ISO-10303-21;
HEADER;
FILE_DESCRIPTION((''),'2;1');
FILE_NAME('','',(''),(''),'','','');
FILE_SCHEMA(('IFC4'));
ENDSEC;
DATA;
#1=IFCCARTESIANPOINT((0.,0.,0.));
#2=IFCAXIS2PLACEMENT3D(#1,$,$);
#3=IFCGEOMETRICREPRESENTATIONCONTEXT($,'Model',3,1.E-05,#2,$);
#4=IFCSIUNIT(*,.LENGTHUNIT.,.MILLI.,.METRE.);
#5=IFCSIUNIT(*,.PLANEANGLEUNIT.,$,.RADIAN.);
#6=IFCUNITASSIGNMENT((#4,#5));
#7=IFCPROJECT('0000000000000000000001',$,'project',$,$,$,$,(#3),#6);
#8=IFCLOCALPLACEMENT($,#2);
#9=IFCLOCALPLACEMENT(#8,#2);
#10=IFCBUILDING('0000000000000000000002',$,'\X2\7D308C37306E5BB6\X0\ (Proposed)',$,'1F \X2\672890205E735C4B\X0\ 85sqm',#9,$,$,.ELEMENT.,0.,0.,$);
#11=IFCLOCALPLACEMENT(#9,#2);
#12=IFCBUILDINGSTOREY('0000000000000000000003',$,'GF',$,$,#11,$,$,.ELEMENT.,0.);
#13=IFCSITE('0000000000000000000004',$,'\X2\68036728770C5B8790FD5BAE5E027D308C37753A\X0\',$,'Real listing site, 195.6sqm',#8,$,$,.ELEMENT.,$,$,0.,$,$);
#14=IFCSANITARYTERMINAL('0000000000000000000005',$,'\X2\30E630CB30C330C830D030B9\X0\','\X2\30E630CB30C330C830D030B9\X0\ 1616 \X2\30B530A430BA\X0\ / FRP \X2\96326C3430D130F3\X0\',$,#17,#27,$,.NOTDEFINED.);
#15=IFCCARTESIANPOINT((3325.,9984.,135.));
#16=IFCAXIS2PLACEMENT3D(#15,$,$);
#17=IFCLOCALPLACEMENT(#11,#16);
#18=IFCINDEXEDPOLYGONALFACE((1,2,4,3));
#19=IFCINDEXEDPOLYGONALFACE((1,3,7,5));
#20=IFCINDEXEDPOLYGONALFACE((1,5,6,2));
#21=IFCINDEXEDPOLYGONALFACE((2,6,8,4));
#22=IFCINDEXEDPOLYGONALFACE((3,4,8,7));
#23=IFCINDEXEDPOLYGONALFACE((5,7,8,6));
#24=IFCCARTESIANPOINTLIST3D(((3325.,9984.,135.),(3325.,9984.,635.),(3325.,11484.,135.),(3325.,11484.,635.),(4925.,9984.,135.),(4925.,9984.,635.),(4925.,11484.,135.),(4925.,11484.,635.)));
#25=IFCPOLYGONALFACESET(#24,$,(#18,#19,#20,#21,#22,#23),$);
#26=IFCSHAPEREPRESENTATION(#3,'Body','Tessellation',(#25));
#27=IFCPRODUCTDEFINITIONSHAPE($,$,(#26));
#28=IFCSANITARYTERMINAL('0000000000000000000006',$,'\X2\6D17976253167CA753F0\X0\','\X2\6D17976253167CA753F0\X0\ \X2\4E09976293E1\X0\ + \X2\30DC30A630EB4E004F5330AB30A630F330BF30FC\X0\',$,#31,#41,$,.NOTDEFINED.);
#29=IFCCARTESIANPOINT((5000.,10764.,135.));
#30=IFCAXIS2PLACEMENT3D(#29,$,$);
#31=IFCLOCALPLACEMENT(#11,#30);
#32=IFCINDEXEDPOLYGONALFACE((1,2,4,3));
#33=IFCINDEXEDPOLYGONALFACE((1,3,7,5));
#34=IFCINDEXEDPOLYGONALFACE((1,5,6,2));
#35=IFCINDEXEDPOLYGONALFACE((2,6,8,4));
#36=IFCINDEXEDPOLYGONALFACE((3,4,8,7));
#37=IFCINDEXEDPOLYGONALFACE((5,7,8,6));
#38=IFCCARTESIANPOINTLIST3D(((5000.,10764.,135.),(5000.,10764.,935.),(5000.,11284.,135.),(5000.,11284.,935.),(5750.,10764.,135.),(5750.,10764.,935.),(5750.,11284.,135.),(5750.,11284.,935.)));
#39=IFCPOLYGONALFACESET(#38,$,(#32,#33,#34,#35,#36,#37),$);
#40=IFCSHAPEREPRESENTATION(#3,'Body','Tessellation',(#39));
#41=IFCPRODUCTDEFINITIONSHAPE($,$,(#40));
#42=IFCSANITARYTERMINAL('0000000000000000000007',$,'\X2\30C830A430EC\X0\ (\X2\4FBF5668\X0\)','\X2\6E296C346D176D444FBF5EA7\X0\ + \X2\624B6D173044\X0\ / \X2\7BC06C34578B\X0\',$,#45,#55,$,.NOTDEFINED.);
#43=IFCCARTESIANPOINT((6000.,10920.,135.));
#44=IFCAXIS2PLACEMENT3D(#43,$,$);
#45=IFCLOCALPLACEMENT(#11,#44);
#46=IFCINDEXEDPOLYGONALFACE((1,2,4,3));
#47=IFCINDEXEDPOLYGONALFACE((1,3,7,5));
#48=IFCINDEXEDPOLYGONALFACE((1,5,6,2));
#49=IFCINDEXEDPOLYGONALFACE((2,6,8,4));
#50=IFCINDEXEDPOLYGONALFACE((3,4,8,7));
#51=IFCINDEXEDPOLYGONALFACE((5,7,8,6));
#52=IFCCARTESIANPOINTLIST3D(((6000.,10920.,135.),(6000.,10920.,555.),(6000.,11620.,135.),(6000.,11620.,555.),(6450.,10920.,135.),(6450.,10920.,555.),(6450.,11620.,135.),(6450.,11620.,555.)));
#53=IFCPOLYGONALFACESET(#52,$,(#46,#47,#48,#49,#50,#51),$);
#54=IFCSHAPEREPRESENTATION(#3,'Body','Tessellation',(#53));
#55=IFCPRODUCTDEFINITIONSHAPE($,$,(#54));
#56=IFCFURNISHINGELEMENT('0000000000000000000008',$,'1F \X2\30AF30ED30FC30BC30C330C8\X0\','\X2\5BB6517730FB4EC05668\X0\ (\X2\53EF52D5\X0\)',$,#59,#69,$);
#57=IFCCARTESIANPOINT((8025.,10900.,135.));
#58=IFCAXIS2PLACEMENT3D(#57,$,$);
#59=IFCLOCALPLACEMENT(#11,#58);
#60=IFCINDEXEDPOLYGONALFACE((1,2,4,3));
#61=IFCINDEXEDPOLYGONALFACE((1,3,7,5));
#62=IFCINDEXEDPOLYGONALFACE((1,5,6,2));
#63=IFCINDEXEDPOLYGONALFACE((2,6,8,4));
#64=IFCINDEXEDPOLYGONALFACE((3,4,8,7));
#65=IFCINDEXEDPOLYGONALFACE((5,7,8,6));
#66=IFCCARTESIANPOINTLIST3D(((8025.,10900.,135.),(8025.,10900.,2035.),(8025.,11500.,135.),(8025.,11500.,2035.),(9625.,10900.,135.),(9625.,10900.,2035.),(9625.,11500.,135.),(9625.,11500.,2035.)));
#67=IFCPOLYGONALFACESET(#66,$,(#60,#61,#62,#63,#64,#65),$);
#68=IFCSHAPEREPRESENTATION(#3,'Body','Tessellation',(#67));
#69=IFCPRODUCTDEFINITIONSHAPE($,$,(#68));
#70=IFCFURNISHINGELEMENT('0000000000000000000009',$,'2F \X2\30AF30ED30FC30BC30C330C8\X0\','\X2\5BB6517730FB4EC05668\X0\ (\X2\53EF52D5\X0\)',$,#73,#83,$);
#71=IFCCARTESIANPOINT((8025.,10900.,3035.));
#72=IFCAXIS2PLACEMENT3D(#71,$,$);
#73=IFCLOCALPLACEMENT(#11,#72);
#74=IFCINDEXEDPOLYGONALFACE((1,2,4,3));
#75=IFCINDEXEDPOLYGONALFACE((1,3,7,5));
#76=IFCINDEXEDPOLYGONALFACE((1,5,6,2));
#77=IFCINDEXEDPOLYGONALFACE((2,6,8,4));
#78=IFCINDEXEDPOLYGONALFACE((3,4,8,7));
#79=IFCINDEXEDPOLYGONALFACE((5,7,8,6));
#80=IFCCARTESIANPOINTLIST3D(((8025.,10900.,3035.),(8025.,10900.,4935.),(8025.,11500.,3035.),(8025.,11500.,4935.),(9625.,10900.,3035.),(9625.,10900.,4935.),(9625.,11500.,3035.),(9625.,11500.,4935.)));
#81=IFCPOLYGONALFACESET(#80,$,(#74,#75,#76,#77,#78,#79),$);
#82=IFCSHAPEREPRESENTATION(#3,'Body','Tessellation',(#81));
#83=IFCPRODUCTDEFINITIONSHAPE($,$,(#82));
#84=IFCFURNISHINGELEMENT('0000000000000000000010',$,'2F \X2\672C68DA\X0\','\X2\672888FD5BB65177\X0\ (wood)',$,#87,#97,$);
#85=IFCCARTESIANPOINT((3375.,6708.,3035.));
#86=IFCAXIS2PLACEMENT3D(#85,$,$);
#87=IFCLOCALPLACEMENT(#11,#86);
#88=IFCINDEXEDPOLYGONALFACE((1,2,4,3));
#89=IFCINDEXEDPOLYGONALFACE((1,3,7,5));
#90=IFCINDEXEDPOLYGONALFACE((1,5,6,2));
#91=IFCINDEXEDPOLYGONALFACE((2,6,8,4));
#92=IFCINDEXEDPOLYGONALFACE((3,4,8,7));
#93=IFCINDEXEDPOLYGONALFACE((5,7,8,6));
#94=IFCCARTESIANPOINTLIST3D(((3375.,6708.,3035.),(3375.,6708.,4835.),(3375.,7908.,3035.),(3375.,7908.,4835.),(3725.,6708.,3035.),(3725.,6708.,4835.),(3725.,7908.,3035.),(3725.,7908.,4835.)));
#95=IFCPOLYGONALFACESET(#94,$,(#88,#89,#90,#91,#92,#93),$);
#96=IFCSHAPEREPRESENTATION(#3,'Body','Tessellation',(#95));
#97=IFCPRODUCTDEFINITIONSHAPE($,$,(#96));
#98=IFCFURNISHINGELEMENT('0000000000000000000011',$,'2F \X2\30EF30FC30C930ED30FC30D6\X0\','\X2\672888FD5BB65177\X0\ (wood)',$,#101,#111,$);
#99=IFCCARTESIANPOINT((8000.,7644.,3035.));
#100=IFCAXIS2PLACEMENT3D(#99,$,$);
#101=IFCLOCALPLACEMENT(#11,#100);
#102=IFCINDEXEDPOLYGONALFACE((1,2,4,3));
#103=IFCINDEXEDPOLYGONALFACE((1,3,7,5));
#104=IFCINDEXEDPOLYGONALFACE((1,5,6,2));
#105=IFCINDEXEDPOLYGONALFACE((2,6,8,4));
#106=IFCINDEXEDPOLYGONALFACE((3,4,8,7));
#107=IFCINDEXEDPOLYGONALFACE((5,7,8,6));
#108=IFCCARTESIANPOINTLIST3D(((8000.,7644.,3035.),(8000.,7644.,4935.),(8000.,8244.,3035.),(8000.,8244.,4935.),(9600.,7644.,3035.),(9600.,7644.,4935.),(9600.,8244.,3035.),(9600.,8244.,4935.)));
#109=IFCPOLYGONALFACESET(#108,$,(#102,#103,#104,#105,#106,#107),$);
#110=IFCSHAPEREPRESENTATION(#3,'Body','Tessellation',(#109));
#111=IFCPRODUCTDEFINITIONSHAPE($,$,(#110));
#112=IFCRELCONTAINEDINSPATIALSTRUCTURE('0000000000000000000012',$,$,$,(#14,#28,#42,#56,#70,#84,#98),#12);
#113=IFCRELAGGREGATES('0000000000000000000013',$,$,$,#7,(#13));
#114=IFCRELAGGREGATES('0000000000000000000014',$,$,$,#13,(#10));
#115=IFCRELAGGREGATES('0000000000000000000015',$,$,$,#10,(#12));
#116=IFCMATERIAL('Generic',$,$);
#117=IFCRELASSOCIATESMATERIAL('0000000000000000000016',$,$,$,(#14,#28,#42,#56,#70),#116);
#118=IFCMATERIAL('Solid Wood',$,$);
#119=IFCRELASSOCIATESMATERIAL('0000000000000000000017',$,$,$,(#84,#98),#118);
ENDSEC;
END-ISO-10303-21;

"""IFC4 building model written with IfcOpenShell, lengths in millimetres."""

from ifc_helpers import new_model, si_unit, frame, frame_2d, origin, place, context, project, spatial, rectangle, extrude, material, element, save


model = new_model("IFC4")

# Units and contexts
model_context = context("Model", 3, precision=1e-05, world=origin())
ifc_project = project(units=[si_unit("LENGTHUNIT", "METRE", prefix="MILLI"), si_unit("PLANEANGLEUNIT", "RADIAN")], contexts=[model_context])

# Site, building, storey
site_placement = place(None, origin())
site = spatial("IfcSite", under=ifc_project, at=site_placement, Name="栃木県宇都宮市細谷町", ObjectType="Real listing site, 195.6sqm", CompositionType="ELEMENT", RefElevation=0.0)
building_placement = place(site_placement, origin())
building = spatial("IfcBuilding", under=site, at=building_placement, Name="細谷の家 (Proposed)", ObjectType="1F 木造平屋 85sqm", CompositionType="ELEMENT", ElevationOfRefHeight=0.0, ElevationOfTerrain=0.0)
storey_placement = place(building_placement, origin())
storey = spatial("IfcBuildingStorey", under=building, at=storey_placement, Name="GF", CompositionType="ELEMENT", Elevation=0.0)

# Shared definitions
ifc_material_1 = material(Name="Solid Wood")

# Shared definitions
ifc_material_2 = material(Name="Generic")

# Sanitary terminals
sanitary_terminal_1_placement = place(storey_placement, frame((3325.0, 9984.0, 135.0)))
element("IfcSanitaryTerminal", 1, at=sanitary_terminal_1_placement, inside=storey, material=ifc_material_2, Name="ユニットバス", Description="ユニットバス 1616 サイズ / FRP 防水パン", PredefinedType="NOTDEFINED", context=model_context, shape_type="SweptSolid", body=[
    extrude(rectangle(XDim=1600.0, YDim=1500.0, at=frame_2d((800.0, 750.0))), frame((3325.0, 9984.0, 135.0)), (0.0, 0.0, 1.0), 500.0),
])
sanitary_terminal_2_placement = place(storey_placement, frame((5000.0, 10764.0, 135.0)))
element("IfcSanitaryTerminal", 2, at=sanitary_terminal_2_placement, inside=storey, material=ifc_material_2, Name="洗面化粧台", Description="洗面化粧台 三面鏡 + ボウル一体カウンター", PredefinedType="NOTDEFINED", context=model_context, shape_type="SweptSolid", body=[
    extrude(rectangle(XDim=750.0, YDim=520.0, at=frame_2d((375.0, 260.0))), frame((5000.0, 10764.0, 135.0)), (0.0, 0.0, 1.0), 800.0),
])
sanitary_terminal_3_placement = place(storey_placement, frame((6000.0, 10920.0, 135.0)))
element("IfcSanitaryTerminal", 3, at=sanitary_terminal_3_placement, inside=storey, material=ifc_material_2, Name="トイレ (便器)", Description="温水洗浄便座 + 手洗い / 節水型", PredefinedType="NOTDEFINED", context=model_context, shape_type="SweptSolid", body=[
    extrude(rectangle(XDim=450.0, YDim=700.0, at=frame_2d((225.0, 350.0))), frame((6000.0, 10920.0, 135.0)), (0.0, 0.0, 1.0), 420.0),
])

# Furnishing elements
furnishing_1_placement = place(storey_placement, frame((8025.0, 10900.0, 135.0)))
element("IfcFurnishingElement", 4, at=furnishing_1_placement, inside=storey, material=ifc_material_2, Name="1F クローゼット", Description="家具・什器 (可動)", context=model_context, shape_type="SweptSolid", body=[
    extrude(rectangle(XDim=1600.0, YDim=600.0, at=frame_2d((800.0, 300.0))), frame((8025.0, 10900.0, 135.0)), (0.0, 0.0, 1.0), 1900.0),
])
furnishing_2_placement = place(storey_placement, frame((8025.0, 10900.0, 3035.0)))
element("IfcFurnishingElement", 5, at=furnishing_2_placement, inside=storey, material=ifc_material_2, Name="2F クローゼット", Description="家具・什器 (可動)", context=model_context, shape_type="SweptSolid", body=[
    extrude(rectangle(XDim=1600.0, YDim=600.0, at=frame_2d((800.0, 300.0))), frame((8025.0, 10900.0, 3035.0)), (0.0, 0.0, 1.0), 1900.0),
])
furnishing_3_placement = place(storey_placement, frame((3375.0, 6708.0, 3035.0)))
element("IfcFurnishingElement", 6, at=furnishing_3_placement, inside=storey, material=ifc_material_1, Name="2F 本棚", Description="木製家具 (wood)", context=model_context, shape_type="SweptSolid", body=[
    extrude(rectangle(XDim=350.0, YDim=1200.0, at=frame_2d((175.0, 600.0))), frame((3375.0, 6708.0, 3035.0)), (0.0, 0.0, 1.0), 1800.0),
])
furnishing_4_placement = place(storey_placement, frame((8000.0, 7644.0, 3035.0)))
element("IfcFurnishingElement", 7, at=furnishing_4_placement, inside=storey, material=ifc_material_1, Name="2F ワードローブ", Description="木製家具 (wood)", context=model_context, shape_type="SweptSolid", body=[
    extrude(rectangle(XDim=1600.0, YDim=600.0, at=frame_2d((800.0, 300.0))), frame((8000.0, 7644.0, 3035.0)), (0.0, 0.0, 1.0), 1900.0),
])

save(model, "model.ifc")
